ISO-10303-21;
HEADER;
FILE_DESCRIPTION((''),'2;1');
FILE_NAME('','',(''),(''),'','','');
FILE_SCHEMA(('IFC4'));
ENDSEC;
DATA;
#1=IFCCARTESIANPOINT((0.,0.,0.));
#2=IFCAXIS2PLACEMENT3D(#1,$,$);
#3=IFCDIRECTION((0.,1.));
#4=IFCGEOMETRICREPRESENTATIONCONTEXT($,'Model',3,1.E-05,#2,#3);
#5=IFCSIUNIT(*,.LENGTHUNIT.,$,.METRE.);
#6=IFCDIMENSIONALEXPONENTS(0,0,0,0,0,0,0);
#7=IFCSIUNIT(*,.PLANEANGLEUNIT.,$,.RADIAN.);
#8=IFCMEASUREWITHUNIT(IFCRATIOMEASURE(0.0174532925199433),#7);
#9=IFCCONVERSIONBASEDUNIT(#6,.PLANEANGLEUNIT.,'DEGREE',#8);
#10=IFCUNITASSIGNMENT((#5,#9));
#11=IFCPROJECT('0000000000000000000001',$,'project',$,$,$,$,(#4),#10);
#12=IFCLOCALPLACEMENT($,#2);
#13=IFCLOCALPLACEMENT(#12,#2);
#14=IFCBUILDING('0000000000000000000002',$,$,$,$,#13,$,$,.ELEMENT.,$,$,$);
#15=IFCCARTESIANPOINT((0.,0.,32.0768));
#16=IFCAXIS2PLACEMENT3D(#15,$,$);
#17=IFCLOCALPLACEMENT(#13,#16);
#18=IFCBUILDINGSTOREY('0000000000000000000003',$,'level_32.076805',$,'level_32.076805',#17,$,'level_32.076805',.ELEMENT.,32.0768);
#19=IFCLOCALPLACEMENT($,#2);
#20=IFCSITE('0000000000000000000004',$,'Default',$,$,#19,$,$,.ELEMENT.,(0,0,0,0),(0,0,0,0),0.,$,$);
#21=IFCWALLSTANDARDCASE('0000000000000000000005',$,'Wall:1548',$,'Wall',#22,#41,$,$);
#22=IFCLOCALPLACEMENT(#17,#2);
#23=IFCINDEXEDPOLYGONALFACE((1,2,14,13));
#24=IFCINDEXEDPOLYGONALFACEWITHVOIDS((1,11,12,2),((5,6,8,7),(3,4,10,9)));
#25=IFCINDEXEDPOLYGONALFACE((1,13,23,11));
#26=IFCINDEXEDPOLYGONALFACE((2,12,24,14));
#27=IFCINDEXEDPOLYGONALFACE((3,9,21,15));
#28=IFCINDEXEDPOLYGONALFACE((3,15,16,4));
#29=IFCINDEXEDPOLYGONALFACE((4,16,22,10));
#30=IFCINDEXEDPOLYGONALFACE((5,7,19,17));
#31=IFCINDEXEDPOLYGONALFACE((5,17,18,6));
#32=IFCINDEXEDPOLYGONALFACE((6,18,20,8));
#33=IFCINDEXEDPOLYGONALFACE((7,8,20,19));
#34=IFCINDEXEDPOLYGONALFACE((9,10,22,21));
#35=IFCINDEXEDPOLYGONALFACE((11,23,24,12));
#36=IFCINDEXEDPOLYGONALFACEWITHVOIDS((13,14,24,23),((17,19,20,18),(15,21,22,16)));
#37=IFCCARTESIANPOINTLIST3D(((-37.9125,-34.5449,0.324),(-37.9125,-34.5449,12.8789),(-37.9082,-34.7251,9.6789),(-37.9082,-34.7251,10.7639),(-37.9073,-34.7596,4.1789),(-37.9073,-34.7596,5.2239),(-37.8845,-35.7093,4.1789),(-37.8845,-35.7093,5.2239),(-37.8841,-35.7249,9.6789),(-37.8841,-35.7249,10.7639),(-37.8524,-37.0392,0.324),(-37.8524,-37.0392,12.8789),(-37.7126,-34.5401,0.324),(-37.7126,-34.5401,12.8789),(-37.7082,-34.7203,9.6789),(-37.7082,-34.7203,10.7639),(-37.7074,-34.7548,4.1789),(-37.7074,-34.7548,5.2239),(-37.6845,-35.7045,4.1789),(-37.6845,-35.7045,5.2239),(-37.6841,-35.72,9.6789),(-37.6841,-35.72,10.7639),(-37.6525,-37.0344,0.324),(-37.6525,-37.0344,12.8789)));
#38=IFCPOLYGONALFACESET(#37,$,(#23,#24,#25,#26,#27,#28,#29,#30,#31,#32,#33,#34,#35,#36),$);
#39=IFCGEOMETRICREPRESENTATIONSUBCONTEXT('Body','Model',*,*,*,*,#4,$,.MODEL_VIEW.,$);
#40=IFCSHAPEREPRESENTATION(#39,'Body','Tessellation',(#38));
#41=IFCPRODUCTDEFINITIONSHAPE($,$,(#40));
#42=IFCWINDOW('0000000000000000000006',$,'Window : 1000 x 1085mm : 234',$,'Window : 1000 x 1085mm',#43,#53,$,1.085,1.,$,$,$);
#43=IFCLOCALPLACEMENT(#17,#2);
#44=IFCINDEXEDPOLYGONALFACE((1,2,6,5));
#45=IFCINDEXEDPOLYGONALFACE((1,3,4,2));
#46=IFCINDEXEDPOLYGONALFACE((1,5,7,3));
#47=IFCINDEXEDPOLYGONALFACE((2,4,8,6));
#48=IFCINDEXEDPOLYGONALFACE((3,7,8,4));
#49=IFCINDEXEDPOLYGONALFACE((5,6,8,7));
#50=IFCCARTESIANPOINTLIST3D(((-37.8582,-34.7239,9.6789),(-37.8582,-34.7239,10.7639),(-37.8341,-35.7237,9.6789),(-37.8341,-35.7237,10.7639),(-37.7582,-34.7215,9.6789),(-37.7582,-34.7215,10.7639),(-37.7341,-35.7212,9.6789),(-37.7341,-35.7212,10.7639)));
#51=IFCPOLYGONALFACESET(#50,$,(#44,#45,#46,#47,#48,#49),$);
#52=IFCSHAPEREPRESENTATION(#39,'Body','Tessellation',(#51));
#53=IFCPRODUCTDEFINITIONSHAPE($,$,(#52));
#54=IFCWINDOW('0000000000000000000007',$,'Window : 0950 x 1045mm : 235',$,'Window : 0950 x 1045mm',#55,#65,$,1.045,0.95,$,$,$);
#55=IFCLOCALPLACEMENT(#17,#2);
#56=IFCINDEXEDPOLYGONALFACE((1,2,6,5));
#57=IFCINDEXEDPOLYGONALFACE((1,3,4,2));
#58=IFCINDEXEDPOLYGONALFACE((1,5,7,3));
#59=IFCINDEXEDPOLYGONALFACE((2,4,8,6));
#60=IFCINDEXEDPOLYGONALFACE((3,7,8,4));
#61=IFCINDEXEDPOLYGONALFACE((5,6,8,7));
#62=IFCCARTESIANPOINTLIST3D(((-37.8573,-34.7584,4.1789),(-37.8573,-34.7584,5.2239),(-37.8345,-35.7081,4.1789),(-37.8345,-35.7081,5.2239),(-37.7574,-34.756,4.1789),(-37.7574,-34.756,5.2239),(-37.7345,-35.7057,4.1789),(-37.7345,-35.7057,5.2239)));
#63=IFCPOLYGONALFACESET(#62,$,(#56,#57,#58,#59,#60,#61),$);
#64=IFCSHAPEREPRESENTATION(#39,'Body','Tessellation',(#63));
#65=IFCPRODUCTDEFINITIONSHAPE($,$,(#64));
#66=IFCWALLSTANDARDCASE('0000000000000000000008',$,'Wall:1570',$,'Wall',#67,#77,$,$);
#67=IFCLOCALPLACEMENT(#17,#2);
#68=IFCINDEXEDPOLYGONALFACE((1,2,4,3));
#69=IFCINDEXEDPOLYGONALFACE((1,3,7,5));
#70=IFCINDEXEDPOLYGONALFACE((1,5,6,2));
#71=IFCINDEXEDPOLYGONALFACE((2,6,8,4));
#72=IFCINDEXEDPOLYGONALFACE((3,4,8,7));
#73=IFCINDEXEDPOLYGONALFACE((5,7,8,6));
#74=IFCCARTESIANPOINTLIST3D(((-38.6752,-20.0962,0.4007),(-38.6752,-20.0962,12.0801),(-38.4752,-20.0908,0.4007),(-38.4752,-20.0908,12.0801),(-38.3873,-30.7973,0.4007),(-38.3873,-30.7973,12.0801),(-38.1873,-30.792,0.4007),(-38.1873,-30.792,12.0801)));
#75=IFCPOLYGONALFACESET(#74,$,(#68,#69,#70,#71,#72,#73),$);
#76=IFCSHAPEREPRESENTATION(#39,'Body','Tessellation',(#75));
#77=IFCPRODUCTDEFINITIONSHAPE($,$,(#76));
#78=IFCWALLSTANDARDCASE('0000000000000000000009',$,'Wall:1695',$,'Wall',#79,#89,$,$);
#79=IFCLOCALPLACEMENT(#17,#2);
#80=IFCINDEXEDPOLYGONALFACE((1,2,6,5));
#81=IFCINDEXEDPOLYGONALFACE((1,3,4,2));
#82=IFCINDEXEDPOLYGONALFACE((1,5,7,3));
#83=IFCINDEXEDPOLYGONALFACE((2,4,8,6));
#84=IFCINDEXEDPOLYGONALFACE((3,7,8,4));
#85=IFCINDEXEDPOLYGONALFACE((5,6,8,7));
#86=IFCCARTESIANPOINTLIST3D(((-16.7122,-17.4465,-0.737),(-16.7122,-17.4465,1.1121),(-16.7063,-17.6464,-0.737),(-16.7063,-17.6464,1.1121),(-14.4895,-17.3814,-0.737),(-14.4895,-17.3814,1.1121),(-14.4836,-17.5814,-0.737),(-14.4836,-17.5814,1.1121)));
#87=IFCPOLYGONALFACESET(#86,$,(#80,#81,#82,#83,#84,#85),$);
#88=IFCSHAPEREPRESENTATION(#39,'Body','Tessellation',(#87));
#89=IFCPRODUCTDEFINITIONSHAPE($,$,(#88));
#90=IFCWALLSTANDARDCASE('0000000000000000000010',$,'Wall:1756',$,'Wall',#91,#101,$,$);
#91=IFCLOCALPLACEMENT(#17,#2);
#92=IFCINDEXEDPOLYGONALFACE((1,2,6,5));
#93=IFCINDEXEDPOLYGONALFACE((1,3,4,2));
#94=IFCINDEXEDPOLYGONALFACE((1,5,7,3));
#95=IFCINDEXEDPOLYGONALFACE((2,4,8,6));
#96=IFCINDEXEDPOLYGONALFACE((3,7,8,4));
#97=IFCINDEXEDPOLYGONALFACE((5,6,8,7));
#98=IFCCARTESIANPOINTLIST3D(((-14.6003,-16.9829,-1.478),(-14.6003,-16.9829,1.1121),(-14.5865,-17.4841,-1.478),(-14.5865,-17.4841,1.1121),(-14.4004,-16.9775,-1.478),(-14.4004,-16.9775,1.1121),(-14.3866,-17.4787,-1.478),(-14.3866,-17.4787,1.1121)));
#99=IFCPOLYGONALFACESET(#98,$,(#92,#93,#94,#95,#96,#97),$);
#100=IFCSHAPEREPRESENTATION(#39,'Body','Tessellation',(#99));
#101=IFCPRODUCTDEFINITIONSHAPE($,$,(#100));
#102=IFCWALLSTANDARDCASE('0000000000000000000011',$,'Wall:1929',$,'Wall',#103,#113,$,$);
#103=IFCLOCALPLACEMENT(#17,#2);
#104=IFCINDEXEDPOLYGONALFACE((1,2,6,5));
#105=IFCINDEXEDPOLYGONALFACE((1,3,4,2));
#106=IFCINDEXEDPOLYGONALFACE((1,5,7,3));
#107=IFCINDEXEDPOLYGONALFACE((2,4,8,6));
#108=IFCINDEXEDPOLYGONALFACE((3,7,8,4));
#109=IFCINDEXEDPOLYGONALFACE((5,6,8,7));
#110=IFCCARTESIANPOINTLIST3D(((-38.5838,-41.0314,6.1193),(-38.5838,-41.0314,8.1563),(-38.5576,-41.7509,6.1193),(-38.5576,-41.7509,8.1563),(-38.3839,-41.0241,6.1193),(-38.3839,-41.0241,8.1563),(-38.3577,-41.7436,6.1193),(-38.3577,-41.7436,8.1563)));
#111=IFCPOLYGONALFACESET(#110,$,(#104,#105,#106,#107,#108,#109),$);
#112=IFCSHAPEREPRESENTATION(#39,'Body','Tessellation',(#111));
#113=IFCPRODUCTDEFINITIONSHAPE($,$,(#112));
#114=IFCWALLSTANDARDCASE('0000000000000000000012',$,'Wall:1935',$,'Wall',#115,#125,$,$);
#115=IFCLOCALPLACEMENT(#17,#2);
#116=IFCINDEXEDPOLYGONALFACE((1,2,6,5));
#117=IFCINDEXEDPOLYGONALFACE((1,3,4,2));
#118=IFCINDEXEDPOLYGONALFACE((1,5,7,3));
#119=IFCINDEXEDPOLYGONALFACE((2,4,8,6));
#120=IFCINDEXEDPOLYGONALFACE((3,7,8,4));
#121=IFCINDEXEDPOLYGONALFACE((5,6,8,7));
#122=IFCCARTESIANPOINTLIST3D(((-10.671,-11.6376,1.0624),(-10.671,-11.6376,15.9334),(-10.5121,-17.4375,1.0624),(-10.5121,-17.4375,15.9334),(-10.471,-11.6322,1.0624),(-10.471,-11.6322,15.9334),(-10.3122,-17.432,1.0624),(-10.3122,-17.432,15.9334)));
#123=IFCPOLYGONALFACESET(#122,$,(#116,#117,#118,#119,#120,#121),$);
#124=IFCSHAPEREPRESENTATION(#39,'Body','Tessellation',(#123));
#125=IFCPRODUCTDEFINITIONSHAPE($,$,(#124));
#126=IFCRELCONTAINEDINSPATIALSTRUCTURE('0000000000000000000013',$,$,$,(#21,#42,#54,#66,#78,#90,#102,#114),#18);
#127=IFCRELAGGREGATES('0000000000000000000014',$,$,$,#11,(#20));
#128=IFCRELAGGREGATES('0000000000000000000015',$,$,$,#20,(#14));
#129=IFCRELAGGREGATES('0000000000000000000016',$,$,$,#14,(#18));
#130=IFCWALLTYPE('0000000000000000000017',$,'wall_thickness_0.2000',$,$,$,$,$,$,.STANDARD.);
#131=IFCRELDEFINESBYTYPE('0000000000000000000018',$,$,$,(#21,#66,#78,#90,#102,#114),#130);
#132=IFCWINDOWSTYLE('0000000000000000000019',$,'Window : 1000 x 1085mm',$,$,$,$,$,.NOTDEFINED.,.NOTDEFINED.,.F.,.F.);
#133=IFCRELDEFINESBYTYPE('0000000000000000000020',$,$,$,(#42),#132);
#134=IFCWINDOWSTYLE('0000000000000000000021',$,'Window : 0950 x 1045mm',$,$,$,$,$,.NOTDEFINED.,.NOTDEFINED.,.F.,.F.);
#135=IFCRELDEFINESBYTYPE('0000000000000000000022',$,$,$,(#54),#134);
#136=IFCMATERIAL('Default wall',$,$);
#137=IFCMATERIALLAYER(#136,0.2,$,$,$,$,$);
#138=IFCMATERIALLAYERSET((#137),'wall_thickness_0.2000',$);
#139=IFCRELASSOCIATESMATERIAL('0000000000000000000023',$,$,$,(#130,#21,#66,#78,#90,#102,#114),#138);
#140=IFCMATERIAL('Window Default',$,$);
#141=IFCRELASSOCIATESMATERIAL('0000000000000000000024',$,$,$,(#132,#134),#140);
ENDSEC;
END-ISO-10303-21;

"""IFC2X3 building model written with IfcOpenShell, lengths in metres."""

from ifc_helpers import new_model, entity, si_unit, converted_unit, direction, frame, frame_2d, origin, origin_2d_with_axis, place, context, subcontext, project, spatial, polyline, rectangle, outline, extrude, source, transform, mapped, material, layer, layer_set, layer_usage, type_object, type_shapes, element, fill, save


model = new_model("IFC2X3")

# Units and contexts
model_context = context("Model", 3, precision=1e-05, world=origin(), true_north=direction((0.0, 1.0)))
body_context = subcontext(model_context, "Body", "Model", "MODEL_VIEW")
ifc_project = project(units=[si_unit("LENGTHUNIT", "METRE"), converted_unit("PLANEANGLEUNIT", "DEGREE", entity("IfcRatioMeasure", 0.0174532925199433), si_unit("PLANEANGLEUNIT", "RADIAN"), dimensions=[0, 0, 0, 0, 0, 0, 0])], contexts=[model_context])

# Site, building, storey
site_placement = place(None, origin())
site = spatial("IfcSite", under=ifc_project, at=site_placement, Name="Default", CompositionType="ELEMENT", RefLatitude=(0, 0, 0, 0), RefLongitude=(0, 0, 0, 0), RefElevation=0.0)
placement_1 = place(None, origin())
building_placement = place(placement_1, origin())
building = spatial("IfcBuilding", under=site, at=building_placement, CompositionType="ELEMENT")
storey_placement = place(building_placement, frame((0.0, 0.0, 32.0768)))
storey = spatial("IfcBuildingStorey", under=building, at=storey_placement, Name="level_32.076805", ObjectType="level_32.076805", LongName="level_32.076805", CompositionType="ELEMENT", Elevation=32.0768)

# Shared definitions
ifc_material_1 = material(Name="Default wall")
ifc_layer = layer(ifc_material_1, 0.2)
ifc_layer_set = layer_set([ifc_layer], Name="wall_thickness_0.2000")
ifc_layer_usage = layer_usage(ifc_layer_set, "AXIS2", "POSITIVE", -0.1)
wall_type = type_object("IfcWallType", Name="wall_thickness_0.2000", PredefinedType="STANDARD", material=ifc_layer_set)

# Wall, openings, windows
placement_2 = place(building_placement, frame((0.0, 0.0, 32.4008)))
wall_1_placement = place(placement_2, frame((-37.8125, -34.5425, 0.0), z_axis=(0.0, 0.0, 1.0), x_axis=(0.024078, -0.99971, 0.0)))
wall_1 = element("IfcWallStandardCase", 1, at=wall_1_placement, inside=storey, type_object=wall_type, material=ifc_layer_usage, Name="Wall:1548", ObjectType="Wall", context=body_context, shape_type="SweptSolid", body=[
    extrude(outline(polyline([(2.495, -0.1), (2.495, 0.1), (0.0, 0.1), (0.0, -0.1), (2.495, -0.1)])), origin(), (0.0, 0.0, 1.0), 12.5549),
])
opening_1_placement = place(wall_1_placement, frame((0.1803, -0.1, 9.3549)))
opening_1 = element("IfcOpeningElement", 2, at=opening_1_placement, cuts=wall_1, ObjectType="Opening", context=body_context, shape_type="SweptSolid", body=[
    extrude(rectangle(XDim=1.0, YDim=1.085, at=frame_2d((0.5425, 0.5), x_axis=(0.0, 1.0))), frame((0.0, 0.0, 0.0), z_axis=(0.0, 1.0, 0.0), x_axis=(0.0, 0.0, 1.0)), (0.0, 0.0, 1.0), 0.2),
])
opening_2_placement = place(wall_1_placement, frame((0.2147, -0.1, 3.8549)))
opening_2 = element("IfcOpeningElement", 3, at=opening_2_placement, cuts=wall_1, ObjectType="Opening", context=body_context, shape_type="SweptSolid", body=[
    extrude(rectangle(XDim=0.95, YDim=1.045, at=frame_2d((0.5225, 0.475), x_axis=(0.0, 1.0))), frame((0.0, 0.0, 0.0), z_axis=(0.0, 1.0, 0.0), x_axis=(0.0, 0.0, 1.0)), (0.0, 0.0, 1.0), 0.2),
])
ifc_material_2 = material(Name="Window Default")
window_style_1 = type_object("IfcWindowStyle", Name="Window : 1000 x 1085mm", ConstructionType="NOTDEFINED", OperationType="NOTDEFINED", ParameterTakesPrecedence=False, Sizeable=False, material=ifc_material_2)
shared_shape_1 = source(origin(), body_context, "Body", "SweptSolid", [
    extrude(rectangle(XDim=0.1, YDim=1.0, at=origin_2d_with_axis()), frame((0.5, 0.1, 0.0), z_axis=(0.0, 0.0, 1.0), x_axis=(0.0, 1.0, 0.0)), (0.0, 0.0, 1.0), 1.085),
])
type_shapes(window_style_1, [shared_shape_1])
window_1_placement = place(opening_1_placement, origin())
window_1 = element("IfcWindow", 4, at=window_1_placement, inside=storey, type_object=window_style_1, Name="Window : 1000 x 1085mm : 234", ObjectType="Window : 1000 x 1085mm", OverallHeight=1.085, OverallWidth=1.0, context=body_context, shape_type="MappedRepresentation", body=[
    mapped(shared_shape_1, transform((0.0, 0.0, 0.0), scale=1.0)),
])
fill(opening_1, window_1)
window_style_2 = type_object("IfcWindowStyle", Name="Window : 0950 x 1045mm", ConstructionType="NOTDEFINED", OperationType="NOTDEFINED", ParameterTakesPrecedence=False, Sizeable=False, material=ifc_material_2)
shared_shape_2 = source(origin(), body_context, "Body", "SweptSolid", [
    extrude(rectangle(XDim=0.1, YDim=0.95, at=origin_2d_with_axis()), frame((0.475, 0.1, 0.0), z_axis=(0.0, 0.0, 1.0), x_axis=(0.0, 1.0, 0.0)), (0.0, 0.0, 1.0), 1.045),
])
type_shapes(window_style_2, [shared_shape_2])
window_2_placement = place(opening_2_placement, origin())
window_2 = element("IfcWindow", 5, at=window_2_placement, inside=storey, type_object=window_style_2, Name="Window : 0950 x 1045mm : 235", ObjectType="Window : 0950 x 1045mm", OverallHeight=1.045, OverallWidth=0.95, context=body_context, shape_type="MappedRepresentation", body=[
    mapped(shared_shape_2, transform((0.0, 0.0, 0.0), scale=1.0)),
])
fill(opening_2, window_2)

# Walls
placement_3 = place(building_placement, frame((0.0, 0.0, 32.4775)))
wall_2_placement = place(placement_3, frame((-38.2873, -30.7946, 0.0), z_axis=(0.0, 0.0, 1.0), x_axis=(-0.026894, 0.999638, 0.0)))
element("IfcWallStandardCase", 6, at=wall_2_placement, inside=storey, type_object=wall_type, material=ifc_layer_usage, Name="Wall:1570", ObjectType="Wall", context=body_context, shape_type="SweptSolid", body=[
    extrude(outline(polyline([(10.705, -0.1), (10.705, 0.1), (0.0, 0.1), (0.0, -0.1), (10.705, -0.1)])), origin(), (0.0, 0.0, 1.0), 11.6794),
])
placement_4 = place(building_placement, frame((0.0, 0.0, 31.3398)))
wall_3_placement = place(placement_4, frame((-16.7092, -17.5465, 0.0), z_axis=(0.0, 0.0, 1.0), x_axis=(0.999572, 0.029259, 0.0)))
element("IfcWallStandardCase", 7, at=wall_3_placement, inside=storey, type_object=wall_type, material=ifc_layer_usage, Name="Wall:1695", ObjectType="Wall", context=body_context, shape_type="SweptSolid", body=[
    extrude(outline(polyline([(2.2236, -0.1), (2.2236, 0.1), (0.0, 0.1), (0.0, -0.1), (2.2236, -0.1)])), origin(), (0.0, 0.0, 1.0), 1.8491),
])
placement_5 = place(building_placement, frame((0.0, 0.0, 30.5988)))
wall_4_placement = place(placement_5, frame((-14.4866, -17.4814, 0.0), z_axis=(0.0, 0.0, 1.0), x_axis=(-0.027443, 0.999623, 0.0)))
element("IfcWallStandardCase", 8, at=wall_4_placement, inside=storey, type_object=wall_type, material=ifc_layer_usage, Name="Wall:1756", ObjectType="Wall", context=body_context, shape_type="SweptSolid", body=[
    extrude(outline(polyline([(0.5014, -0.1), (0.5014, 0.1), (0.0, 0.1), (0.0, -0.1), (0.5014, -0.1)])), origin(), (0.0, 0.0, 1.0), 2.5901),
])
placement_6 = place(building_placement, frame((0.0, 0.0, 38.1961)))
wall_5_placement = place(placement_6, frame((-38.4839, -41.0277, 0.0), z_axis=(0.0, 0.0, 1.0), x_axis=(0.036425, -0.999336, 0.0)))
element("IfcWallStandardCase", 9, at=wall_5_placement, inside=storey, type_object=wall_type, material=ifc_layer_usage, Name="Wall:1929", ObjectType="Wall", context=body_context, shape_type="SweptSolid", body=[
    extrude(outline(polyline([(0.72, -0.1), (0.72, 0.1), (0.0, 0.1), (0.0, -0.1), (0.72, -0.1)])), origin(), (0.0, 0.0, 1.0), 2.037),
])
placement_7 = place(building_placement, frame((0.0, 0.0, 33.1392)))
wall_6_placement = place(placement_7, frame((-10.4121, -17.4347, 0.0), z_axis=(0.0, 0.0, 1.0), x_axis=(-0.027385, 0.999625, 0.0)))
element("IfcWallStandardCase", 10, at=wall_6_placement, inside=storey, type_object=wall_type, material=ifc_layer_usage, Name="Wall:1935", ObjectType="Wall", context=body_context, shape_type="SweptSolid", body=[
    extrude(outline(polyline([(5.802, -0.1), (5.802, 0.1), (0.0, 0.1), (0.0, -0.1), (5.802, -0.1)])), origin(), (0.0, 0.0, 1.0), 14.871),
])

save(model, "model.ifc")
